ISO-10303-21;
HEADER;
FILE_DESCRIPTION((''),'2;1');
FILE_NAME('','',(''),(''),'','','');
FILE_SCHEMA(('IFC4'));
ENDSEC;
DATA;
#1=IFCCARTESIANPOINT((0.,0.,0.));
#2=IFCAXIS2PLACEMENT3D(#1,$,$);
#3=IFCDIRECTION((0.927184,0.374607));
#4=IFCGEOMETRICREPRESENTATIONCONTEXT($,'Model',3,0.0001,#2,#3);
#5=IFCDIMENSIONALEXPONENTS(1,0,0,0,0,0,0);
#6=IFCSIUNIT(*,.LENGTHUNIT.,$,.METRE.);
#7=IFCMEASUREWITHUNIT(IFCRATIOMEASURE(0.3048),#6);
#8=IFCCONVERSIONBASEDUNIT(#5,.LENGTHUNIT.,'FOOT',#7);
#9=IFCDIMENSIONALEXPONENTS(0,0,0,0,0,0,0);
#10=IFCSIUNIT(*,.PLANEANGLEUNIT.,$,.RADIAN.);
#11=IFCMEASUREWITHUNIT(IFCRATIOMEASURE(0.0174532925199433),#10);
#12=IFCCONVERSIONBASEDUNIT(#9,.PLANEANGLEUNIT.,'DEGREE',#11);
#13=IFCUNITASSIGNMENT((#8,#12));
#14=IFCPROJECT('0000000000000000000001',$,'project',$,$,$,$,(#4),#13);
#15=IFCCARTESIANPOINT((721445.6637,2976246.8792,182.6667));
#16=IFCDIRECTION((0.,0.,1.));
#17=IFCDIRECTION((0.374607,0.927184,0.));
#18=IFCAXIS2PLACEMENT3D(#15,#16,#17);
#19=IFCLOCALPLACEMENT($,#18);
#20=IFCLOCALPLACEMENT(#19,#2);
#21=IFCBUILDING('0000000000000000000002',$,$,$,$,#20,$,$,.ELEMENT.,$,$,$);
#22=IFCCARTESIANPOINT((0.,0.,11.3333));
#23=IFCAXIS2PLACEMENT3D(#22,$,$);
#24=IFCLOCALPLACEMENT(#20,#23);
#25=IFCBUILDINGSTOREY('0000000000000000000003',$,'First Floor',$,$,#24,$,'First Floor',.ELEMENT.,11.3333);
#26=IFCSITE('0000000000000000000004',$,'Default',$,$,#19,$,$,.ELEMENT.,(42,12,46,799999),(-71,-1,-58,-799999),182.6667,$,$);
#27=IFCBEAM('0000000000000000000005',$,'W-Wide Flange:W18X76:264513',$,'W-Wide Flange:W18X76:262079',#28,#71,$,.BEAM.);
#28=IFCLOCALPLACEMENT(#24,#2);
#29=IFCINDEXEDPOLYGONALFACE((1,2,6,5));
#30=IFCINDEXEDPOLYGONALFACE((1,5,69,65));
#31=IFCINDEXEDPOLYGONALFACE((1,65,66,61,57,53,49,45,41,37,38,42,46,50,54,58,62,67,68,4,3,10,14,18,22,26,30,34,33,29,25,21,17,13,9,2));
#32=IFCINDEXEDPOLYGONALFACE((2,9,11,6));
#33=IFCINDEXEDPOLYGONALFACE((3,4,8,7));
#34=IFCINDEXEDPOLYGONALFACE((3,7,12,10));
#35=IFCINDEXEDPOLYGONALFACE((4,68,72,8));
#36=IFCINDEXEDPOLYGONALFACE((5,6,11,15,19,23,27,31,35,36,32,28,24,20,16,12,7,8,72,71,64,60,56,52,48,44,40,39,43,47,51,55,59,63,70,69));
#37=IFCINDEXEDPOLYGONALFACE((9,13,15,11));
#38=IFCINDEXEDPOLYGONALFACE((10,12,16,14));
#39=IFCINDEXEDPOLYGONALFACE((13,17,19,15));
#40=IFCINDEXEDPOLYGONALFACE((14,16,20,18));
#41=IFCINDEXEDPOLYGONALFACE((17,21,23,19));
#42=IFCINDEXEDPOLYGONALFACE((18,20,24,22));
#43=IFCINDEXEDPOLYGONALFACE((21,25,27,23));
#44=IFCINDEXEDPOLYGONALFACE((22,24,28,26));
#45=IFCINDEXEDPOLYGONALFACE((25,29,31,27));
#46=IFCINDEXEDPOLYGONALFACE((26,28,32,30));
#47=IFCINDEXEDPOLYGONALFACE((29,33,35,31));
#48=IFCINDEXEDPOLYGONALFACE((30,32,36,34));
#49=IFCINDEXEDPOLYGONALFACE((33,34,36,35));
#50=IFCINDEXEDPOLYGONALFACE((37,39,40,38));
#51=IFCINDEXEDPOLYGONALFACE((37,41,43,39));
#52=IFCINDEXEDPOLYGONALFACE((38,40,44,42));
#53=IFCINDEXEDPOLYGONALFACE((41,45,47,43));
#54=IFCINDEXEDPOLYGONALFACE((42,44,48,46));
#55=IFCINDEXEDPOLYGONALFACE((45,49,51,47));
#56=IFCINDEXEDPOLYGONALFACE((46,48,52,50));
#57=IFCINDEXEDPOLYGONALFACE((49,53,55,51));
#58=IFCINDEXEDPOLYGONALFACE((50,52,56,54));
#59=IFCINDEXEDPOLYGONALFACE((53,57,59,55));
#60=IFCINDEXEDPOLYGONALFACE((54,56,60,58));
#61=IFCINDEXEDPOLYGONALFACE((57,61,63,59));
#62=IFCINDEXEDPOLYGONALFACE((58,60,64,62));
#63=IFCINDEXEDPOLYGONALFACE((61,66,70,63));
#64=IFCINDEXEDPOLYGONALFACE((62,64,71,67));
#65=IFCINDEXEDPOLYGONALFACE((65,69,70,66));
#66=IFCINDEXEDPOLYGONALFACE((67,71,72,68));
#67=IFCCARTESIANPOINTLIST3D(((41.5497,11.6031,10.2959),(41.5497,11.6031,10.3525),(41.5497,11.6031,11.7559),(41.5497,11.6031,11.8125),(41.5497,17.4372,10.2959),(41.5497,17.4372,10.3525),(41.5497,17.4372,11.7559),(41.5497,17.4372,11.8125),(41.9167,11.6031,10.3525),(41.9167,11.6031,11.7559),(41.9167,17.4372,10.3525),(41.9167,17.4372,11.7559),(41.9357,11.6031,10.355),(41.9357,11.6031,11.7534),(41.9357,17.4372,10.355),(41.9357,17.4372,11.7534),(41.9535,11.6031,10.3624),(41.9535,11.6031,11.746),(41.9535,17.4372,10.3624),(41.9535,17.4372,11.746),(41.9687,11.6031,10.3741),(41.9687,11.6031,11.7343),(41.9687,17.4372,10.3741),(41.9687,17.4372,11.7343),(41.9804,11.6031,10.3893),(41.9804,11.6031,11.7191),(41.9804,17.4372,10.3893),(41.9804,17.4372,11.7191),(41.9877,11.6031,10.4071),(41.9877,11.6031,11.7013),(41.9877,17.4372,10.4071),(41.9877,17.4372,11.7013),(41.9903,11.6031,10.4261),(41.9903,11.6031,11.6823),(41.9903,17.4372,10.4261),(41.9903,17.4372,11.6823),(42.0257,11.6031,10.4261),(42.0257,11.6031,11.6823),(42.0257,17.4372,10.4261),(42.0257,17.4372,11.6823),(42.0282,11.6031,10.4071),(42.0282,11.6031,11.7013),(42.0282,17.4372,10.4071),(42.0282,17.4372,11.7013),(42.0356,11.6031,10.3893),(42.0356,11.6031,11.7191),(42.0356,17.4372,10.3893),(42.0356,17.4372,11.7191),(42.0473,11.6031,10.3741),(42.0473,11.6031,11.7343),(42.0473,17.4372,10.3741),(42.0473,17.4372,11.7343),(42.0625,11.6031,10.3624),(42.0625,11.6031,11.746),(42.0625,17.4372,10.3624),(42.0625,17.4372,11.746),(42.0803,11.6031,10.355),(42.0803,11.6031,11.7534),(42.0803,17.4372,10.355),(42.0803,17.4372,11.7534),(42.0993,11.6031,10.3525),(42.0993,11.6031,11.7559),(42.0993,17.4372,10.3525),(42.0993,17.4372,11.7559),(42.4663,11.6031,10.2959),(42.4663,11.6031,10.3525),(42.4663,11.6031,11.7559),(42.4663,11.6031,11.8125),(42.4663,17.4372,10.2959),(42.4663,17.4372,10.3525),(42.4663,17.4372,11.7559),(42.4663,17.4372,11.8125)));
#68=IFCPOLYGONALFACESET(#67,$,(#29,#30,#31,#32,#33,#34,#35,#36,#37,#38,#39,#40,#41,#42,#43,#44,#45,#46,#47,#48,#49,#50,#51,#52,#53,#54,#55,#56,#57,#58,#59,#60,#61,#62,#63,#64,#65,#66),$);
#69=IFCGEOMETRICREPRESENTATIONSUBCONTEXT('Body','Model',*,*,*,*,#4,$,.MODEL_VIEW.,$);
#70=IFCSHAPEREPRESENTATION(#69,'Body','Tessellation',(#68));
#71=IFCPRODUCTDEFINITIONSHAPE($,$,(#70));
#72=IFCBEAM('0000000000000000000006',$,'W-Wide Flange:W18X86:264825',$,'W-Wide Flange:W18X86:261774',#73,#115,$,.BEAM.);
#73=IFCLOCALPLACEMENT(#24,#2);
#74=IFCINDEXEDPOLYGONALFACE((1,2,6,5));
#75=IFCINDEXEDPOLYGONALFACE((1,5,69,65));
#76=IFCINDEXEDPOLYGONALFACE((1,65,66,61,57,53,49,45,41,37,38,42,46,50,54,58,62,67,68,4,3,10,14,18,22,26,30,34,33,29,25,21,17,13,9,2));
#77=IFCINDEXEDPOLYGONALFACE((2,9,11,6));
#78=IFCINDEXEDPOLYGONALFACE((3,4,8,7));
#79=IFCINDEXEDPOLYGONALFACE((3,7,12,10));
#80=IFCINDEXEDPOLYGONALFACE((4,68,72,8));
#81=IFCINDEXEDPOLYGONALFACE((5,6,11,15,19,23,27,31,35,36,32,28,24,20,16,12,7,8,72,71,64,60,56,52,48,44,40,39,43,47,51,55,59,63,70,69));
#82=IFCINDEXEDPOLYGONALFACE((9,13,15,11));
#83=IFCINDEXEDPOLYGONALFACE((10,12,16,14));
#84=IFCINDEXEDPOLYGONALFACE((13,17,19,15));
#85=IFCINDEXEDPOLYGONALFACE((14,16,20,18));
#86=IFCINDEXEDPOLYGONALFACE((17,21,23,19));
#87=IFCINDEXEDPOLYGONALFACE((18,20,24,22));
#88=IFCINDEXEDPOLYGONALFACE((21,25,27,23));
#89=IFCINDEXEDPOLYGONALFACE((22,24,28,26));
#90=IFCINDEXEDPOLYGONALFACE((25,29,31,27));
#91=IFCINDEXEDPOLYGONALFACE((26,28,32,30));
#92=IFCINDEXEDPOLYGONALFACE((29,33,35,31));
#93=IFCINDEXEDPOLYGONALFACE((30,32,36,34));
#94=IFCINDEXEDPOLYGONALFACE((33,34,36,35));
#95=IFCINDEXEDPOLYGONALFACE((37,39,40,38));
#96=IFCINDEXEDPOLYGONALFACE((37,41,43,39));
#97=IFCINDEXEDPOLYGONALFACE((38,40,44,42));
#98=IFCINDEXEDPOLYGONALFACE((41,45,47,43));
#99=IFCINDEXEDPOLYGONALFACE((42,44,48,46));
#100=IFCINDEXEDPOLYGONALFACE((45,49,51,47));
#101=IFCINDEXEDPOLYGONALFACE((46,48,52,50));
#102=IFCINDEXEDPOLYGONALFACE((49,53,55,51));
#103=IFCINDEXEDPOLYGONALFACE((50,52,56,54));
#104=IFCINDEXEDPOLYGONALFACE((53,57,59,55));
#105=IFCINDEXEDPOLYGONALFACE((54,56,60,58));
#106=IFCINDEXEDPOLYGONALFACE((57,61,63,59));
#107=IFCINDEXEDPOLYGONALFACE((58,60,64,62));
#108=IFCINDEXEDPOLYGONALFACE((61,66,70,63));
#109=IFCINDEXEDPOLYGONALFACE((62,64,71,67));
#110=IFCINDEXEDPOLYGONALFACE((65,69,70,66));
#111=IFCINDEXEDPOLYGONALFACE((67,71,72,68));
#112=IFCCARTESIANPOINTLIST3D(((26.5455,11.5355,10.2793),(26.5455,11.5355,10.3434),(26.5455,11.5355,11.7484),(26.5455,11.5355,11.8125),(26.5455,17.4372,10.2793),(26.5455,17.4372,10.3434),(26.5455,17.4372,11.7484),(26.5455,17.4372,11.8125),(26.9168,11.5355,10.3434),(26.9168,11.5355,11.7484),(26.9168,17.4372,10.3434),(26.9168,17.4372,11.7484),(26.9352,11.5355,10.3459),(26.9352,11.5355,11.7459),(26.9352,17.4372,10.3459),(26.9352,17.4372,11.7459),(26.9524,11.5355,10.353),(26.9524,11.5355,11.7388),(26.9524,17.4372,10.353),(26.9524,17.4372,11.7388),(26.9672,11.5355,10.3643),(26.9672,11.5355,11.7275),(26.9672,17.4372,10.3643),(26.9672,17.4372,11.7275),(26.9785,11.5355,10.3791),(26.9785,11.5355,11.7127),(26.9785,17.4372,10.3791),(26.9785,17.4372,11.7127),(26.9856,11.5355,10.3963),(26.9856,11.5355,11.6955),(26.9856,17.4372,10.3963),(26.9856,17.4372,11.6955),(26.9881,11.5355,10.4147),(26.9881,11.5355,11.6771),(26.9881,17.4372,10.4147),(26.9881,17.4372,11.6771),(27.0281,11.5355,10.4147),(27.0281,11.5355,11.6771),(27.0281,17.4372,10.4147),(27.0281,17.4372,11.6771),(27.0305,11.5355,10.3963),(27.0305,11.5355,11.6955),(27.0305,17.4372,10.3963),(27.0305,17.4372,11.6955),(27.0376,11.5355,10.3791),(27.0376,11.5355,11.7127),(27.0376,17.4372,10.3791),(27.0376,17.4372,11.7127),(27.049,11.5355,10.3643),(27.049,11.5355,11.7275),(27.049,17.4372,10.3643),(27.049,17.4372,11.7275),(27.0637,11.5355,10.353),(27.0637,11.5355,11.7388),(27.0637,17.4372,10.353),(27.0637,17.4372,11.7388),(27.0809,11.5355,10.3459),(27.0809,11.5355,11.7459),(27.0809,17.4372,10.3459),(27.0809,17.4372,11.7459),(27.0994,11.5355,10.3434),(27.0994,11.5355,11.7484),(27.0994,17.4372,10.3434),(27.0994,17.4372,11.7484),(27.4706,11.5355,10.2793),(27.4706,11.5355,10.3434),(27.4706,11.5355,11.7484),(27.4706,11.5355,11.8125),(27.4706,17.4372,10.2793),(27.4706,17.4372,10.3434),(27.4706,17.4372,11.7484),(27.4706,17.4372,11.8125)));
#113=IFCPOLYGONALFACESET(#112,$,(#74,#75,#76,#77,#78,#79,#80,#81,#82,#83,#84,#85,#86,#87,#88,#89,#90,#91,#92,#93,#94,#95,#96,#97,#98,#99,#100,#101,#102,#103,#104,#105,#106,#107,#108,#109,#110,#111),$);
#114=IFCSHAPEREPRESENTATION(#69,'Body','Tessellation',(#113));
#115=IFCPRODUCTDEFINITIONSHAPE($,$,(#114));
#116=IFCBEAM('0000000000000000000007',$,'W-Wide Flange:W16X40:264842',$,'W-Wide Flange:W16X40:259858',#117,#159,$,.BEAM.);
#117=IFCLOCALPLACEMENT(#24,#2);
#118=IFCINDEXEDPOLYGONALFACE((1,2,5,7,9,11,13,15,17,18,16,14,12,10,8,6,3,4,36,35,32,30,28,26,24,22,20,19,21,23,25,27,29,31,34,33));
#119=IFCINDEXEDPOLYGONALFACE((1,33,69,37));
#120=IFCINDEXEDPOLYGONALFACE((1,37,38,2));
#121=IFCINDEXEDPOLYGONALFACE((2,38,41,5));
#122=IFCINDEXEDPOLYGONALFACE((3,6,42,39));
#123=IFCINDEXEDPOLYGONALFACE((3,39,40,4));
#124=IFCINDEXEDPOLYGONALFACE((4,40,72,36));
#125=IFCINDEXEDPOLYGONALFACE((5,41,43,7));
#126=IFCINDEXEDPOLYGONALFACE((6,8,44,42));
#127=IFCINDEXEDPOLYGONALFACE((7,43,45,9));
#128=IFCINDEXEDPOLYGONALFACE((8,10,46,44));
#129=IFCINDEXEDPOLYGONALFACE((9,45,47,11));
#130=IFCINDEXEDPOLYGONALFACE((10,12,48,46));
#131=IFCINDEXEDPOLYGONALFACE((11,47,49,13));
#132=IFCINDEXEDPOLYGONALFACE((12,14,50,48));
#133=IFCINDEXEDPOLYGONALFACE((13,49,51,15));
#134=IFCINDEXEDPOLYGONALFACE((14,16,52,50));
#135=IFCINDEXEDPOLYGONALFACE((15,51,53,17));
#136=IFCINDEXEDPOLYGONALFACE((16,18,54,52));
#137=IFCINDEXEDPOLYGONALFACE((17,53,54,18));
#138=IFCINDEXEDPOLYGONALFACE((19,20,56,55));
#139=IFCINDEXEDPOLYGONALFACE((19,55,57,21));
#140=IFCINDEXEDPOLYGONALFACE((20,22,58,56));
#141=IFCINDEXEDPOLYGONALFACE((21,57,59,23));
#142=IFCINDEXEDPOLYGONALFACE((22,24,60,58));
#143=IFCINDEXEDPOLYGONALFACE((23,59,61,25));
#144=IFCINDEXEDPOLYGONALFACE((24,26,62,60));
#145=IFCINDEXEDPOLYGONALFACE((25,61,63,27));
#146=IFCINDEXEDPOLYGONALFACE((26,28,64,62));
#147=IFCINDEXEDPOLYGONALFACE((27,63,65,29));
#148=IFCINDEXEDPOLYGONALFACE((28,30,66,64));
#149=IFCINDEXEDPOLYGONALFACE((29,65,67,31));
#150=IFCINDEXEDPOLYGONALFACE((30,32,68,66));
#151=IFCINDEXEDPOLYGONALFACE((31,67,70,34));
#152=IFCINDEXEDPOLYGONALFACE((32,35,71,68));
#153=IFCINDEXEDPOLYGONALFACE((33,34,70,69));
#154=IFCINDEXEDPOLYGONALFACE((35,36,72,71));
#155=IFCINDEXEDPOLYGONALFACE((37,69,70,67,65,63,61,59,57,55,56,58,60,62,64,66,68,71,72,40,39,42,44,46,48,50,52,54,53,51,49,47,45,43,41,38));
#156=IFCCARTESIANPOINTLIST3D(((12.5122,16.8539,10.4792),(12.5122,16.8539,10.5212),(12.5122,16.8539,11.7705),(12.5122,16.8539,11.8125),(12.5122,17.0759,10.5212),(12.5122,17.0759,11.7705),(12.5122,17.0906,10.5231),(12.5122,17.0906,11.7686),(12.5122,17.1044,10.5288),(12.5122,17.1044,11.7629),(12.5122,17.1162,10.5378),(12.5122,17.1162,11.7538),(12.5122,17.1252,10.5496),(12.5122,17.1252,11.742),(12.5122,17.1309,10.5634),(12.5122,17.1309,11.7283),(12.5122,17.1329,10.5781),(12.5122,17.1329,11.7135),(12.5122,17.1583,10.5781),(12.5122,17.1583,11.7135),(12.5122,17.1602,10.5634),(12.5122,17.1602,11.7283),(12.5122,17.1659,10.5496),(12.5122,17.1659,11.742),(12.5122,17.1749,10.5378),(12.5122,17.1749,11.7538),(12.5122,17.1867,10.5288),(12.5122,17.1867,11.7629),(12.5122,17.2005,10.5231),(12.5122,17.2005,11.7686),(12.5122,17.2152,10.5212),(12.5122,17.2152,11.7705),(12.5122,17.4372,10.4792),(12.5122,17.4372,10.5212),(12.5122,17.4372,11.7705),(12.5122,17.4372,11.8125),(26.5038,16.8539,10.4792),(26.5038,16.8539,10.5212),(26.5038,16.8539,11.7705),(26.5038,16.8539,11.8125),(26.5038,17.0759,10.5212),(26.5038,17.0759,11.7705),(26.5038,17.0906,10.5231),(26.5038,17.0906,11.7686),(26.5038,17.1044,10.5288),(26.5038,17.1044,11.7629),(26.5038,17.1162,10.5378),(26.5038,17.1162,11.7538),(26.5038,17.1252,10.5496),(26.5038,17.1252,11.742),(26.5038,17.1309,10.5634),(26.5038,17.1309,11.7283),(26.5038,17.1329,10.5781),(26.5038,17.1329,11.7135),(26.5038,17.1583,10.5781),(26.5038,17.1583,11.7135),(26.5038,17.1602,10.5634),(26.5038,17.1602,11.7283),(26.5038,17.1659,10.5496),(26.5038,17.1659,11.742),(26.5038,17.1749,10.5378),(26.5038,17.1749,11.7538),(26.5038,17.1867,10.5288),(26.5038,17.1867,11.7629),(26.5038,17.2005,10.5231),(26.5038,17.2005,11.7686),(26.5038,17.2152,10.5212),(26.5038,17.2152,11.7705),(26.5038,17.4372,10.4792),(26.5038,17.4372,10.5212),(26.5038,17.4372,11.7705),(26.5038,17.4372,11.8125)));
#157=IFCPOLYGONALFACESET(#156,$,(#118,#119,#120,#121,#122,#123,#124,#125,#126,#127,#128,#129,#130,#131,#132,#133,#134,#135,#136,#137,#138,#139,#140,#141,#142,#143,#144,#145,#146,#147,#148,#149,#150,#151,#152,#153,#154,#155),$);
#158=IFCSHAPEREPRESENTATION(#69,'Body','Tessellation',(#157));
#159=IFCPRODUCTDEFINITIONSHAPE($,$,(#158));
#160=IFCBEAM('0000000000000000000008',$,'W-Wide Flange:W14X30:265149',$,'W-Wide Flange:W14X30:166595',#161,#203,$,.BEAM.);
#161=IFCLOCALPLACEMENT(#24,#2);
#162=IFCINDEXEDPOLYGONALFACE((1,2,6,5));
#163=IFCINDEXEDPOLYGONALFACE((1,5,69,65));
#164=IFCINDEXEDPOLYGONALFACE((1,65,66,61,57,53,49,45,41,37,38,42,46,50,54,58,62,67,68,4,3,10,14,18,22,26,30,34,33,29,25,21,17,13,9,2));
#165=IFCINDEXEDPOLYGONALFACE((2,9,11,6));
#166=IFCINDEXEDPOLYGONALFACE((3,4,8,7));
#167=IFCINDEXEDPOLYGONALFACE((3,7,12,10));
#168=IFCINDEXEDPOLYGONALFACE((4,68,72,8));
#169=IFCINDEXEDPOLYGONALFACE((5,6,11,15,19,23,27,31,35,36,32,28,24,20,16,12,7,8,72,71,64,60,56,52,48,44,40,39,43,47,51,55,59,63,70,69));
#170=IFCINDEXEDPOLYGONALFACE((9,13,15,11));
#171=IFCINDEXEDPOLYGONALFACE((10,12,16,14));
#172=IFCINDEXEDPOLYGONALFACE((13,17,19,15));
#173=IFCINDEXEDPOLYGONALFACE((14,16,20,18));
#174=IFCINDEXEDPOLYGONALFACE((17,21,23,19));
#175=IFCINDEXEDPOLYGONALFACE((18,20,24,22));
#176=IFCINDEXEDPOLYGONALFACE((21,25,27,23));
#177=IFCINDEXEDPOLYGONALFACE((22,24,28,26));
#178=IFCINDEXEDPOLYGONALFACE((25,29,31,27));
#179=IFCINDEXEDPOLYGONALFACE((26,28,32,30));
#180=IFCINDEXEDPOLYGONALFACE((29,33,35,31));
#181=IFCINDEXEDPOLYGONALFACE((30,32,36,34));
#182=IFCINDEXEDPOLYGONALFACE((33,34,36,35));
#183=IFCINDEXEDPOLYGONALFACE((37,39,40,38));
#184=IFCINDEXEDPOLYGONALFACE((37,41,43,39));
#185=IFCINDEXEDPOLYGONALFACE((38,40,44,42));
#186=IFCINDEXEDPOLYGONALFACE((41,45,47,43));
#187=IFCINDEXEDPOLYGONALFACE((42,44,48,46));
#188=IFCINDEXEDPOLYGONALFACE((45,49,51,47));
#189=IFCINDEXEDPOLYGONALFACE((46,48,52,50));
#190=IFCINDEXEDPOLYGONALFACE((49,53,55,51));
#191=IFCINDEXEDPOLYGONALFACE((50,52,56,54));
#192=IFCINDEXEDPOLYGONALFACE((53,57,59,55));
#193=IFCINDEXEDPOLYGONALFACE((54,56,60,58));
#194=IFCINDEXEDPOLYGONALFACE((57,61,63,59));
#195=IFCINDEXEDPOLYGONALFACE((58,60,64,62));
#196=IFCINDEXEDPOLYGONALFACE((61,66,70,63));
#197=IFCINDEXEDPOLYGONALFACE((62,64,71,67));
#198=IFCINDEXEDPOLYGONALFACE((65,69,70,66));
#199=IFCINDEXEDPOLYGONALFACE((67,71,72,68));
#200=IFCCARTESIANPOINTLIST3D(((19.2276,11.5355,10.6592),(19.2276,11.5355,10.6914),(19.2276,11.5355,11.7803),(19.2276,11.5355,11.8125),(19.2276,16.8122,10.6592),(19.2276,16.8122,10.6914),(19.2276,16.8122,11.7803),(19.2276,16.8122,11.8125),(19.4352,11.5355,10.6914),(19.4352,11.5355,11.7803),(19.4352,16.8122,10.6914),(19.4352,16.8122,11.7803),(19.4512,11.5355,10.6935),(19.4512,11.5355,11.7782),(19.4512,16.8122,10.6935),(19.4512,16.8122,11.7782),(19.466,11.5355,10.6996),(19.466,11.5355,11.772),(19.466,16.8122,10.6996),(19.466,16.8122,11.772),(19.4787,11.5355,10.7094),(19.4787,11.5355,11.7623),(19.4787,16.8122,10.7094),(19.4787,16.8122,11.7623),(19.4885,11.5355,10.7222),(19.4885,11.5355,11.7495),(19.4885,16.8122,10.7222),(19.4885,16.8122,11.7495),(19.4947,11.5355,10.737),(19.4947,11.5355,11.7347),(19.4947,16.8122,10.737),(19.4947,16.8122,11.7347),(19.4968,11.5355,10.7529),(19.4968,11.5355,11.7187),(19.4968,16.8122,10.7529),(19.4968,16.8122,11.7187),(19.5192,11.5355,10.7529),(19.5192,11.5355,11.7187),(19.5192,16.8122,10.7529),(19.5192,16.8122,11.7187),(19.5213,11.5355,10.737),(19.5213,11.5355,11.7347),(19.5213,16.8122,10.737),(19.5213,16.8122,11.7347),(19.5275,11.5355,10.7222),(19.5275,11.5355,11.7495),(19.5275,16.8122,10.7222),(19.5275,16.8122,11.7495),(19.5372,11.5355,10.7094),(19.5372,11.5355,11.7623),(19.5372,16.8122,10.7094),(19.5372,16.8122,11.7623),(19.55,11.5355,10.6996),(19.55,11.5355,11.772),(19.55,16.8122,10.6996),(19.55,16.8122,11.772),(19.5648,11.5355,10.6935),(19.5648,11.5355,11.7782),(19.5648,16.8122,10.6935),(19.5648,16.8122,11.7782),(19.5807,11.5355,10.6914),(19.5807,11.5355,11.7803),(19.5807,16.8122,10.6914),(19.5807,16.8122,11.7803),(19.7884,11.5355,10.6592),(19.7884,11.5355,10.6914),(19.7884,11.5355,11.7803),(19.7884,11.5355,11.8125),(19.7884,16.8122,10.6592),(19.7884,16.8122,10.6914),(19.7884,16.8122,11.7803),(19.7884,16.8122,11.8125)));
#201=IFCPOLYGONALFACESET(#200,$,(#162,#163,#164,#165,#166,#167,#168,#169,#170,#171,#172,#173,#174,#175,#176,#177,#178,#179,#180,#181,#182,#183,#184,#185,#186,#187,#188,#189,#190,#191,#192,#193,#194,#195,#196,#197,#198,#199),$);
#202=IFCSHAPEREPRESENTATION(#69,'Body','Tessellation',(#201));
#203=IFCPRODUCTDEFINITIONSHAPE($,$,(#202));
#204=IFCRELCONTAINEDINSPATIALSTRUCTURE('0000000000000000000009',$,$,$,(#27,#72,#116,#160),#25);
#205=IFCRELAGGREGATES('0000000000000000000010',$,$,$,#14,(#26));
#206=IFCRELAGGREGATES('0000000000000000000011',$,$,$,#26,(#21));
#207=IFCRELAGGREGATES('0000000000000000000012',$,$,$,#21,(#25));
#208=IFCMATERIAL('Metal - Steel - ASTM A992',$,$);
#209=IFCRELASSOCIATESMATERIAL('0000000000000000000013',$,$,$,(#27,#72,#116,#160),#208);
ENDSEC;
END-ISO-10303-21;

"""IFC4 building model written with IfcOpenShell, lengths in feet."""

from ifc_helpers import new_model, entity, si_unit, converted_unit, direction, frame, frame_2d, origin, place, context, subcontext, project, spatial, i_section, extrude, material, element, save


model = new_model("IFC4")

# Units and contexts
model_context = context("Model", 3, precision=0.0001, world=origin(), true_north=direction((0.927184, 0.374607)))
body_context = subcontext(model_context, "Body", "Model", "MODEL_VIEW")
ifc_project = project(units=[converted_unit("LENGTHUNIT", "FOOT", entity("IfcRatioMeasure", 0.3048), si_unit("LENGTHUNIT", "METRE"), dimensions=[1, 0, 0, 0, 0, 0, 0]), converted_unit("PLANEANGLEUNIT", "DEGREE", entity("IfcRatioMeasure", 0.0174532925199433), si_unit("PLANEANGLEUNIT", "RADIAN"), dimensions=[0, 0, 0, 0, 0, 0, 0])], contexts=[model_context])

# Site, building, storey
site_placement = place(None, frame((721445.6637, 2976246.8792, 182.6667), z_axis=(0.0, 0.0, 1.0), x_axis=(0.374607, 0.927184, 0.0)))
site = spatial("IfcSite", under=ifc_project, at=site_placement, Name="Default", CompositionType="ELEMENT", RefLatitude=(42, 12, 46, 799999), RefLongitude=(-71, -1, -58, -799999), RefElevation=182.6667)
building_placement = place(site_placement, origin())
building = spatial("IfcBuilding", under=site, at=building_placement, CompositionType="ELEMENT")
storey_placement = place(building_placement, frame((0.0, 0.0, 11.3333)))
storey = spatial("IfcBuildingStorey", under=building, at=storey_placement, Name="First Floor", LongName="First Floor", CompositionType="ELEMENT", Elevation=11.3333)

# Shared definitions
ifc_material_1 = material(Name="Metal - Steel - ASTM A992")

# Beams
beam_1_placement = place(storey_placement, frame((42.008, 11.1456, 11.8125), z_axis=(0.0, 0.0, 1.0), x_axis=(0.0, 1.0, 0.0)))
element("IfcBeam", 1, at=beam_1_placement, inside=storey, material=ifc_material_1, Name="W-Wide Flange:W18X76:264513", ObjectType="W-Wide Flange:W18X76:262079", PredefinedType="BEAM", context=body_context, shape_type="SweptSolid", body=[
    extrude(i_section(OverallWidth=0.9167, OverallDepth=1.5166, WebThickness=0.0355, FlangeThickness=0.0566, FilletRadius=0.0736, at=frame_2d((0.0, 0.0), x_axis=(0.0, 1.0))), frame((0.4575, 0.0, -0.7583), z_axis=(1.0, 0.0, 0.0), x_axis=(0.0, 0.0, -1.0)), (0.0, 0.0, 1.0), 5.8341),
])
beam_2_placement = place(storey_placement, frame((27.0081, 11.1456, 11.8125), z_axis=(0.0, 0.0, 1.0), x_axis=(0.0, 1.0, 0.0)))
element("IfcBeam", 2, at=beam_2_placement, inside=storey, material=ifc_material_1, Name="W-Wide Flange:W18X86:264825", ObjectType="W-Wide Flange:W18X86:261774", PredefinedType="BEAM", context=body_context, shape_type="SweptSolid", body=[
    extrude(i_section(OverallWidth=0.9251, OverallDepth=1.5332, WebThickness=0.04, FlangeThickness=0.0641, FilletRadius=0.0713, at=frame_2d((0.0, 0.0), x_axis=(0.0, 1.0))), frame((0.39, 0.0, -0.7666), z_axis=(1.0, 0.0, 0.0), x_axis=(0.0, 0.0, -1.0)), (0.0, 0.0, 1.0), 5.9017),
])
beam_3_placement = place(storey_placement, frame((12.008, 17.1456, 11.8125)))
element("IfcBeam", 3, at=beam_3_placement, inside=storey, material=ifc_material_1, Name="W-Wide Flange:W16X40:264842", ObjectType="W-Wide Flange:W16X40:259858", PredefinedType="BEAM", context=body_context, shape_type="SweptSolid", body=[
    extrude(i_section(OverallWidth=0.5833, OverallDepth=1.3333, WebThickness=0.0254, FlangeThickness=0.042, FilletRadius=0.057, at=frame_2d((0.0, 0.0), x_axis=(0.0, 1.0))), frame((0.5042, 0.0, -0.6667), z_axis=(1.0, 0.0, 0.0), x_axis=(0.0, 0.0, -1.0)), (0.0, 0.0, 1.0), 13.9916),
])
beam_4_placement = place(storey_placement, frame((19.508, 11.1456, 11.8125), z_axis=(0.0, 0.0, 1.0), x_axis=(0.0, 1.0, 0.0)))
element("IfcBeam", 4, at=beam_4_placement, inside=storey, material=ifc_material_1, Name="W-Wide Flange:W14X30:265149", ObjectType="W-Wide Flange:W14X30:166595", PredefinedType="BEAM", context=body_context, shape_type="SweptSolid", body=[
    extrude(i_section(OverallWidth=0.5609, OverallDepth=1.1533, WebThickness=0.0225, FlangeThickness=0.0322, FilletRadius=0.0615, at=frame_2d((0.0, 0.0), x_axis=(0.0, 1.0))), frame((0.39, 0.0, -0.5767), z_axis=(1.0, 0.0, 0.0), x_axis=(0.0, 0.0, -1.0)), (0.0, 0.0, 1.0), 5.2767),
])

save(model, "model.ifc")
